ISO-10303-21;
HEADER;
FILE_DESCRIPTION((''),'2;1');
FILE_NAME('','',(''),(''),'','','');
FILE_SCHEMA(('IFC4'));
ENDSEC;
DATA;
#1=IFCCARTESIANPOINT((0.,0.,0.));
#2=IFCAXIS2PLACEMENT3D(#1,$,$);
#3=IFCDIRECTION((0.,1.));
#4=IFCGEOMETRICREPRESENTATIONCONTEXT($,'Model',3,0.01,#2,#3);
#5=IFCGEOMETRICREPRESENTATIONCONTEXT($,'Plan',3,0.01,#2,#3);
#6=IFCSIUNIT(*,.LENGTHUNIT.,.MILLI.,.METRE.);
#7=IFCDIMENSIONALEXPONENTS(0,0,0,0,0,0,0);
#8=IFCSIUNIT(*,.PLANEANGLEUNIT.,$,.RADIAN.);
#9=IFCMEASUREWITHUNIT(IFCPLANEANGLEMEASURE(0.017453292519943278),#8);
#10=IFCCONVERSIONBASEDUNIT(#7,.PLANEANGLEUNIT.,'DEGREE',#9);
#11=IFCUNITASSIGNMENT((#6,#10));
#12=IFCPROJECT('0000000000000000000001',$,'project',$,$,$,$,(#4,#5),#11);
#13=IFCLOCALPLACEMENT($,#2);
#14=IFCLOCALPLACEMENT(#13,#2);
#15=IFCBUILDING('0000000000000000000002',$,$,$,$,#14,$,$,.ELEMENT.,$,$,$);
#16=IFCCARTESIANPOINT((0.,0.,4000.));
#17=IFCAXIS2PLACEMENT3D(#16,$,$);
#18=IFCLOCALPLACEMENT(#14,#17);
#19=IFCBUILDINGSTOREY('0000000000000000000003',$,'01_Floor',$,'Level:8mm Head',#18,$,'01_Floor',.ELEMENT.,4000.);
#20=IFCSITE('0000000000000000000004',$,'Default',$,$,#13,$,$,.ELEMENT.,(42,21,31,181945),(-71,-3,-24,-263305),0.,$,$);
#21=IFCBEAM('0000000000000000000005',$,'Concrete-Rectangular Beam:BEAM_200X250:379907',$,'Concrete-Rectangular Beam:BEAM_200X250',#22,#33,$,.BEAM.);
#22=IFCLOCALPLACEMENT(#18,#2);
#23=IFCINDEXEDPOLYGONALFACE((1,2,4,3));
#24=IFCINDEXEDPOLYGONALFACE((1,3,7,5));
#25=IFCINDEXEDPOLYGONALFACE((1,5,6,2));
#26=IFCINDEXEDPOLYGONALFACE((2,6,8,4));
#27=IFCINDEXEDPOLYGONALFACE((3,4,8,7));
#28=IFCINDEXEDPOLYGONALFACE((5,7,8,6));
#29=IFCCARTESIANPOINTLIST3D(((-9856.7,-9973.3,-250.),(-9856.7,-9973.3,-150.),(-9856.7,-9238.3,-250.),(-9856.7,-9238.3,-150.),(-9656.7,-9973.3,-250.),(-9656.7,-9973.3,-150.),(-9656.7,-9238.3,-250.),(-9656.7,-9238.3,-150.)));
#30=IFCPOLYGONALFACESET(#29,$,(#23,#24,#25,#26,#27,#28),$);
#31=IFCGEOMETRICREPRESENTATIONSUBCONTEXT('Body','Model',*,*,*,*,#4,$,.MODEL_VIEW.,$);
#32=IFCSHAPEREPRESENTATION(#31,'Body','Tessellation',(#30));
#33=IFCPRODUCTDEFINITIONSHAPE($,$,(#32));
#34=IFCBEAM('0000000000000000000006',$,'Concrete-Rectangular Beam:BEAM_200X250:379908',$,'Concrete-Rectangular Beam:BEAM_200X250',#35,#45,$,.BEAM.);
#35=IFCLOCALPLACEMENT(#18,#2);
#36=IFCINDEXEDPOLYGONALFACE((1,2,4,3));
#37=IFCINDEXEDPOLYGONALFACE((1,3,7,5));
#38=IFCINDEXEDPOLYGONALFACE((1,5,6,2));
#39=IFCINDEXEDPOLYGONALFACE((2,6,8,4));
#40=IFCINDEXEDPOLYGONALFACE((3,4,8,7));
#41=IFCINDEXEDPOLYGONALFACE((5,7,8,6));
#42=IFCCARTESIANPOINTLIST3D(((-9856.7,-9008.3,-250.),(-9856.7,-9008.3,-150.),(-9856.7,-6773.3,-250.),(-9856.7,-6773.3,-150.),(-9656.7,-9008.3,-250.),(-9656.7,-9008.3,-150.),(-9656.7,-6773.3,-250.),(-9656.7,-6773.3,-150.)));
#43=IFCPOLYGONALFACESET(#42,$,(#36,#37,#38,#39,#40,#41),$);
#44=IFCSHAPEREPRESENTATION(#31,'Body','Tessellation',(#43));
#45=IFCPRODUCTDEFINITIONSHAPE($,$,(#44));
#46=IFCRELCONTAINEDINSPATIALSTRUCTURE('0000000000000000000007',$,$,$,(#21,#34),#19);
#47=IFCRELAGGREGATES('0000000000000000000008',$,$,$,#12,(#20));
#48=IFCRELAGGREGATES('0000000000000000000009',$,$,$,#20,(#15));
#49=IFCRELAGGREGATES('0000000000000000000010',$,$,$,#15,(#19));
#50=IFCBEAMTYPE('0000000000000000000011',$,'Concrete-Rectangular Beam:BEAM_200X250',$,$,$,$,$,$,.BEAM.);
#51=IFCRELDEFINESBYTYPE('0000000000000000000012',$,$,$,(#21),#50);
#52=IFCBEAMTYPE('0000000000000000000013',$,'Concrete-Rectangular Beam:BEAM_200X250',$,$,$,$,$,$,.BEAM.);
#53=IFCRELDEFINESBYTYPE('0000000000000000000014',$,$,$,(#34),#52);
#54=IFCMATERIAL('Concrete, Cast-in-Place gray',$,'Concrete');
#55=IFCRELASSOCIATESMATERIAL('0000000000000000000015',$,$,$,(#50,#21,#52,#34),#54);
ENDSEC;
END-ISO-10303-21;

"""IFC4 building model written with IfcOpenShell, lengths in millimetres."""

from ifc_helpers import new_model, entity, si_unit, converted_unit, direction, frame, origin, place, context, subcontext, project, spatial, indexed_curve, outline, extrude, source, transform, mapped, material, type_object, type_shapes, element, save


model = new_model("IFC4")

# Units and contexts
model_context = context("Model", 3, precision=0.01, world=origin(), true_north=direction((0.0, 1.0)))
plan_context = context("Plan", 3, precision=0.01, world=origin(), true_north=direction((0.0, 1.0)))
body_context = subcontext(model_context, "Body", "Model", "MODEL_VIEW")
ifc_project = project(units=[si_unit("LENGTHUNIT", "METRE", prefix="MILLI"), converted_unit("PLANEANGLEUNIT", "DEGREE", entity("IfcPlaneAngleMeasure", 0.017453292519943278), si_unit("PLANEANGLEUNIT", "RADIAN"), dimensions=[0, 0, 0, 0, 0, 0, 0])], contexts=[model_context, plan_context])

# Site, building, storey
site_placement = place(None, origin())
site = spatial("IfcSite", under=ifc_project, at=site_placement, Name="Default", CompositionType="ELEMENT", RefLatitude=(42, 21, 31, 181945), RefLongitude=(-71, -3, -24, -263305), RefElevation=0.0)
building_placement = place(site_placement, origin())
building = spatial("IfcBuilding", under=site, at=building_placement, CompositionType="ELEMENT")
storey_placement = place(building_placement, frame((0.0, 0.0, 4000.0)))
storey = spatial("IfcBuildingStorey", under=building, at=storey_placement, Name="01_Floor", ObjectType="Level:8mm Head", LongName="01_Floor", CompositionType="ELEMENT", Elevation=4000.0)

# Beams
ifc_material = material(Name="Concrete, Cast-in-Place gray", Category="Concrete")
beam_type_1 = type_object("IfcBeamType", Name="Concrete-Rectangular Beam:BEAM_200X250", PredefinedType="BEAM", material=ifc_material)
shared_shape_1 = source(origin(), body_context, "Body", "SweptSolid", [
    extrude(outline(indexed_curve([(-100.0, -50.0), (100.0, -50.0), (100.0, 50.0), (-100.0, 50.0), (-100.0, -50.0)], self_intersect=False)), frame((-9756.7, -9973.3, 3800.0), z_axis=(0.0, 1.0, 0.0), x_axis=(-1.0, 0.0, 0.0)), (0.0, 0.0, 1.0), 735.0),
])
type_shapes(beam_type_1, [shared_shape_1])
beam_1_placement = place(storey_placement, frame((0.0, 0.0, -4000.0)))
element("IfcBeam", 1, at=beam_1_placement, inside=storey, type_object=beam_type_1, material=ifc_material, Name="Concrete-Rectangular Beam:BEAM_200X250:379907", ObjectType="Concrete-Rectangular Beam:BEAM_200X250", PredefinedType="BEAM", context=body_context, shape_type="MappedRepresentation", body=[
    mapped(shared_shape_1, transform((0.0, 0.0, 0.0), scale=1.0)),
])
beam_type_2 = type_object("IfcBeamType", Name="Concrete-Rectangular Beam:BEAM_200X250", PredefinedType="BEAM", material=ifc_material)
shared_shape_2 = source(origin(), body_context, "Body", "SweptSolid", [
    extrude(outline(indexed_curve([(-100.0, -50.0), (100.0, -50.0), (100.0, 50.0), (-100.0, 50.0), (-100.0, -50.0)], self_intersect=False)), frame((-9756.7, -9008.3, 3800.0), z_axis=(0.0, 1.0, 0.0), x_axis=(-1.0, 0.0, 0.0)), (0.0, 0.0, 1.0), 2235.0),
])
type_shapes(beam_type_2, [shared_shape_2])
beam_2_placement = place(storey_placement, frame((0.0, 0.0, -4000.0)))
element("IfcBeam", 2, at=beam_2_placement, inside=storey, type_object=beam_type_2, material=ifc_material, Name="Concrete-Rectangular Beam:BEAM_200X250:379908", ObjectType="Concrete-Rectangular Beam:BEAM_200X250", PredefinedType="BEAM", context=body_context, shape_type="MappedRepresentation", body=[
    mapped(shared_shape_2, transform((0.0, 0.0, 0.0), scale=1.0)),
])

save(model, "model.ifc")
